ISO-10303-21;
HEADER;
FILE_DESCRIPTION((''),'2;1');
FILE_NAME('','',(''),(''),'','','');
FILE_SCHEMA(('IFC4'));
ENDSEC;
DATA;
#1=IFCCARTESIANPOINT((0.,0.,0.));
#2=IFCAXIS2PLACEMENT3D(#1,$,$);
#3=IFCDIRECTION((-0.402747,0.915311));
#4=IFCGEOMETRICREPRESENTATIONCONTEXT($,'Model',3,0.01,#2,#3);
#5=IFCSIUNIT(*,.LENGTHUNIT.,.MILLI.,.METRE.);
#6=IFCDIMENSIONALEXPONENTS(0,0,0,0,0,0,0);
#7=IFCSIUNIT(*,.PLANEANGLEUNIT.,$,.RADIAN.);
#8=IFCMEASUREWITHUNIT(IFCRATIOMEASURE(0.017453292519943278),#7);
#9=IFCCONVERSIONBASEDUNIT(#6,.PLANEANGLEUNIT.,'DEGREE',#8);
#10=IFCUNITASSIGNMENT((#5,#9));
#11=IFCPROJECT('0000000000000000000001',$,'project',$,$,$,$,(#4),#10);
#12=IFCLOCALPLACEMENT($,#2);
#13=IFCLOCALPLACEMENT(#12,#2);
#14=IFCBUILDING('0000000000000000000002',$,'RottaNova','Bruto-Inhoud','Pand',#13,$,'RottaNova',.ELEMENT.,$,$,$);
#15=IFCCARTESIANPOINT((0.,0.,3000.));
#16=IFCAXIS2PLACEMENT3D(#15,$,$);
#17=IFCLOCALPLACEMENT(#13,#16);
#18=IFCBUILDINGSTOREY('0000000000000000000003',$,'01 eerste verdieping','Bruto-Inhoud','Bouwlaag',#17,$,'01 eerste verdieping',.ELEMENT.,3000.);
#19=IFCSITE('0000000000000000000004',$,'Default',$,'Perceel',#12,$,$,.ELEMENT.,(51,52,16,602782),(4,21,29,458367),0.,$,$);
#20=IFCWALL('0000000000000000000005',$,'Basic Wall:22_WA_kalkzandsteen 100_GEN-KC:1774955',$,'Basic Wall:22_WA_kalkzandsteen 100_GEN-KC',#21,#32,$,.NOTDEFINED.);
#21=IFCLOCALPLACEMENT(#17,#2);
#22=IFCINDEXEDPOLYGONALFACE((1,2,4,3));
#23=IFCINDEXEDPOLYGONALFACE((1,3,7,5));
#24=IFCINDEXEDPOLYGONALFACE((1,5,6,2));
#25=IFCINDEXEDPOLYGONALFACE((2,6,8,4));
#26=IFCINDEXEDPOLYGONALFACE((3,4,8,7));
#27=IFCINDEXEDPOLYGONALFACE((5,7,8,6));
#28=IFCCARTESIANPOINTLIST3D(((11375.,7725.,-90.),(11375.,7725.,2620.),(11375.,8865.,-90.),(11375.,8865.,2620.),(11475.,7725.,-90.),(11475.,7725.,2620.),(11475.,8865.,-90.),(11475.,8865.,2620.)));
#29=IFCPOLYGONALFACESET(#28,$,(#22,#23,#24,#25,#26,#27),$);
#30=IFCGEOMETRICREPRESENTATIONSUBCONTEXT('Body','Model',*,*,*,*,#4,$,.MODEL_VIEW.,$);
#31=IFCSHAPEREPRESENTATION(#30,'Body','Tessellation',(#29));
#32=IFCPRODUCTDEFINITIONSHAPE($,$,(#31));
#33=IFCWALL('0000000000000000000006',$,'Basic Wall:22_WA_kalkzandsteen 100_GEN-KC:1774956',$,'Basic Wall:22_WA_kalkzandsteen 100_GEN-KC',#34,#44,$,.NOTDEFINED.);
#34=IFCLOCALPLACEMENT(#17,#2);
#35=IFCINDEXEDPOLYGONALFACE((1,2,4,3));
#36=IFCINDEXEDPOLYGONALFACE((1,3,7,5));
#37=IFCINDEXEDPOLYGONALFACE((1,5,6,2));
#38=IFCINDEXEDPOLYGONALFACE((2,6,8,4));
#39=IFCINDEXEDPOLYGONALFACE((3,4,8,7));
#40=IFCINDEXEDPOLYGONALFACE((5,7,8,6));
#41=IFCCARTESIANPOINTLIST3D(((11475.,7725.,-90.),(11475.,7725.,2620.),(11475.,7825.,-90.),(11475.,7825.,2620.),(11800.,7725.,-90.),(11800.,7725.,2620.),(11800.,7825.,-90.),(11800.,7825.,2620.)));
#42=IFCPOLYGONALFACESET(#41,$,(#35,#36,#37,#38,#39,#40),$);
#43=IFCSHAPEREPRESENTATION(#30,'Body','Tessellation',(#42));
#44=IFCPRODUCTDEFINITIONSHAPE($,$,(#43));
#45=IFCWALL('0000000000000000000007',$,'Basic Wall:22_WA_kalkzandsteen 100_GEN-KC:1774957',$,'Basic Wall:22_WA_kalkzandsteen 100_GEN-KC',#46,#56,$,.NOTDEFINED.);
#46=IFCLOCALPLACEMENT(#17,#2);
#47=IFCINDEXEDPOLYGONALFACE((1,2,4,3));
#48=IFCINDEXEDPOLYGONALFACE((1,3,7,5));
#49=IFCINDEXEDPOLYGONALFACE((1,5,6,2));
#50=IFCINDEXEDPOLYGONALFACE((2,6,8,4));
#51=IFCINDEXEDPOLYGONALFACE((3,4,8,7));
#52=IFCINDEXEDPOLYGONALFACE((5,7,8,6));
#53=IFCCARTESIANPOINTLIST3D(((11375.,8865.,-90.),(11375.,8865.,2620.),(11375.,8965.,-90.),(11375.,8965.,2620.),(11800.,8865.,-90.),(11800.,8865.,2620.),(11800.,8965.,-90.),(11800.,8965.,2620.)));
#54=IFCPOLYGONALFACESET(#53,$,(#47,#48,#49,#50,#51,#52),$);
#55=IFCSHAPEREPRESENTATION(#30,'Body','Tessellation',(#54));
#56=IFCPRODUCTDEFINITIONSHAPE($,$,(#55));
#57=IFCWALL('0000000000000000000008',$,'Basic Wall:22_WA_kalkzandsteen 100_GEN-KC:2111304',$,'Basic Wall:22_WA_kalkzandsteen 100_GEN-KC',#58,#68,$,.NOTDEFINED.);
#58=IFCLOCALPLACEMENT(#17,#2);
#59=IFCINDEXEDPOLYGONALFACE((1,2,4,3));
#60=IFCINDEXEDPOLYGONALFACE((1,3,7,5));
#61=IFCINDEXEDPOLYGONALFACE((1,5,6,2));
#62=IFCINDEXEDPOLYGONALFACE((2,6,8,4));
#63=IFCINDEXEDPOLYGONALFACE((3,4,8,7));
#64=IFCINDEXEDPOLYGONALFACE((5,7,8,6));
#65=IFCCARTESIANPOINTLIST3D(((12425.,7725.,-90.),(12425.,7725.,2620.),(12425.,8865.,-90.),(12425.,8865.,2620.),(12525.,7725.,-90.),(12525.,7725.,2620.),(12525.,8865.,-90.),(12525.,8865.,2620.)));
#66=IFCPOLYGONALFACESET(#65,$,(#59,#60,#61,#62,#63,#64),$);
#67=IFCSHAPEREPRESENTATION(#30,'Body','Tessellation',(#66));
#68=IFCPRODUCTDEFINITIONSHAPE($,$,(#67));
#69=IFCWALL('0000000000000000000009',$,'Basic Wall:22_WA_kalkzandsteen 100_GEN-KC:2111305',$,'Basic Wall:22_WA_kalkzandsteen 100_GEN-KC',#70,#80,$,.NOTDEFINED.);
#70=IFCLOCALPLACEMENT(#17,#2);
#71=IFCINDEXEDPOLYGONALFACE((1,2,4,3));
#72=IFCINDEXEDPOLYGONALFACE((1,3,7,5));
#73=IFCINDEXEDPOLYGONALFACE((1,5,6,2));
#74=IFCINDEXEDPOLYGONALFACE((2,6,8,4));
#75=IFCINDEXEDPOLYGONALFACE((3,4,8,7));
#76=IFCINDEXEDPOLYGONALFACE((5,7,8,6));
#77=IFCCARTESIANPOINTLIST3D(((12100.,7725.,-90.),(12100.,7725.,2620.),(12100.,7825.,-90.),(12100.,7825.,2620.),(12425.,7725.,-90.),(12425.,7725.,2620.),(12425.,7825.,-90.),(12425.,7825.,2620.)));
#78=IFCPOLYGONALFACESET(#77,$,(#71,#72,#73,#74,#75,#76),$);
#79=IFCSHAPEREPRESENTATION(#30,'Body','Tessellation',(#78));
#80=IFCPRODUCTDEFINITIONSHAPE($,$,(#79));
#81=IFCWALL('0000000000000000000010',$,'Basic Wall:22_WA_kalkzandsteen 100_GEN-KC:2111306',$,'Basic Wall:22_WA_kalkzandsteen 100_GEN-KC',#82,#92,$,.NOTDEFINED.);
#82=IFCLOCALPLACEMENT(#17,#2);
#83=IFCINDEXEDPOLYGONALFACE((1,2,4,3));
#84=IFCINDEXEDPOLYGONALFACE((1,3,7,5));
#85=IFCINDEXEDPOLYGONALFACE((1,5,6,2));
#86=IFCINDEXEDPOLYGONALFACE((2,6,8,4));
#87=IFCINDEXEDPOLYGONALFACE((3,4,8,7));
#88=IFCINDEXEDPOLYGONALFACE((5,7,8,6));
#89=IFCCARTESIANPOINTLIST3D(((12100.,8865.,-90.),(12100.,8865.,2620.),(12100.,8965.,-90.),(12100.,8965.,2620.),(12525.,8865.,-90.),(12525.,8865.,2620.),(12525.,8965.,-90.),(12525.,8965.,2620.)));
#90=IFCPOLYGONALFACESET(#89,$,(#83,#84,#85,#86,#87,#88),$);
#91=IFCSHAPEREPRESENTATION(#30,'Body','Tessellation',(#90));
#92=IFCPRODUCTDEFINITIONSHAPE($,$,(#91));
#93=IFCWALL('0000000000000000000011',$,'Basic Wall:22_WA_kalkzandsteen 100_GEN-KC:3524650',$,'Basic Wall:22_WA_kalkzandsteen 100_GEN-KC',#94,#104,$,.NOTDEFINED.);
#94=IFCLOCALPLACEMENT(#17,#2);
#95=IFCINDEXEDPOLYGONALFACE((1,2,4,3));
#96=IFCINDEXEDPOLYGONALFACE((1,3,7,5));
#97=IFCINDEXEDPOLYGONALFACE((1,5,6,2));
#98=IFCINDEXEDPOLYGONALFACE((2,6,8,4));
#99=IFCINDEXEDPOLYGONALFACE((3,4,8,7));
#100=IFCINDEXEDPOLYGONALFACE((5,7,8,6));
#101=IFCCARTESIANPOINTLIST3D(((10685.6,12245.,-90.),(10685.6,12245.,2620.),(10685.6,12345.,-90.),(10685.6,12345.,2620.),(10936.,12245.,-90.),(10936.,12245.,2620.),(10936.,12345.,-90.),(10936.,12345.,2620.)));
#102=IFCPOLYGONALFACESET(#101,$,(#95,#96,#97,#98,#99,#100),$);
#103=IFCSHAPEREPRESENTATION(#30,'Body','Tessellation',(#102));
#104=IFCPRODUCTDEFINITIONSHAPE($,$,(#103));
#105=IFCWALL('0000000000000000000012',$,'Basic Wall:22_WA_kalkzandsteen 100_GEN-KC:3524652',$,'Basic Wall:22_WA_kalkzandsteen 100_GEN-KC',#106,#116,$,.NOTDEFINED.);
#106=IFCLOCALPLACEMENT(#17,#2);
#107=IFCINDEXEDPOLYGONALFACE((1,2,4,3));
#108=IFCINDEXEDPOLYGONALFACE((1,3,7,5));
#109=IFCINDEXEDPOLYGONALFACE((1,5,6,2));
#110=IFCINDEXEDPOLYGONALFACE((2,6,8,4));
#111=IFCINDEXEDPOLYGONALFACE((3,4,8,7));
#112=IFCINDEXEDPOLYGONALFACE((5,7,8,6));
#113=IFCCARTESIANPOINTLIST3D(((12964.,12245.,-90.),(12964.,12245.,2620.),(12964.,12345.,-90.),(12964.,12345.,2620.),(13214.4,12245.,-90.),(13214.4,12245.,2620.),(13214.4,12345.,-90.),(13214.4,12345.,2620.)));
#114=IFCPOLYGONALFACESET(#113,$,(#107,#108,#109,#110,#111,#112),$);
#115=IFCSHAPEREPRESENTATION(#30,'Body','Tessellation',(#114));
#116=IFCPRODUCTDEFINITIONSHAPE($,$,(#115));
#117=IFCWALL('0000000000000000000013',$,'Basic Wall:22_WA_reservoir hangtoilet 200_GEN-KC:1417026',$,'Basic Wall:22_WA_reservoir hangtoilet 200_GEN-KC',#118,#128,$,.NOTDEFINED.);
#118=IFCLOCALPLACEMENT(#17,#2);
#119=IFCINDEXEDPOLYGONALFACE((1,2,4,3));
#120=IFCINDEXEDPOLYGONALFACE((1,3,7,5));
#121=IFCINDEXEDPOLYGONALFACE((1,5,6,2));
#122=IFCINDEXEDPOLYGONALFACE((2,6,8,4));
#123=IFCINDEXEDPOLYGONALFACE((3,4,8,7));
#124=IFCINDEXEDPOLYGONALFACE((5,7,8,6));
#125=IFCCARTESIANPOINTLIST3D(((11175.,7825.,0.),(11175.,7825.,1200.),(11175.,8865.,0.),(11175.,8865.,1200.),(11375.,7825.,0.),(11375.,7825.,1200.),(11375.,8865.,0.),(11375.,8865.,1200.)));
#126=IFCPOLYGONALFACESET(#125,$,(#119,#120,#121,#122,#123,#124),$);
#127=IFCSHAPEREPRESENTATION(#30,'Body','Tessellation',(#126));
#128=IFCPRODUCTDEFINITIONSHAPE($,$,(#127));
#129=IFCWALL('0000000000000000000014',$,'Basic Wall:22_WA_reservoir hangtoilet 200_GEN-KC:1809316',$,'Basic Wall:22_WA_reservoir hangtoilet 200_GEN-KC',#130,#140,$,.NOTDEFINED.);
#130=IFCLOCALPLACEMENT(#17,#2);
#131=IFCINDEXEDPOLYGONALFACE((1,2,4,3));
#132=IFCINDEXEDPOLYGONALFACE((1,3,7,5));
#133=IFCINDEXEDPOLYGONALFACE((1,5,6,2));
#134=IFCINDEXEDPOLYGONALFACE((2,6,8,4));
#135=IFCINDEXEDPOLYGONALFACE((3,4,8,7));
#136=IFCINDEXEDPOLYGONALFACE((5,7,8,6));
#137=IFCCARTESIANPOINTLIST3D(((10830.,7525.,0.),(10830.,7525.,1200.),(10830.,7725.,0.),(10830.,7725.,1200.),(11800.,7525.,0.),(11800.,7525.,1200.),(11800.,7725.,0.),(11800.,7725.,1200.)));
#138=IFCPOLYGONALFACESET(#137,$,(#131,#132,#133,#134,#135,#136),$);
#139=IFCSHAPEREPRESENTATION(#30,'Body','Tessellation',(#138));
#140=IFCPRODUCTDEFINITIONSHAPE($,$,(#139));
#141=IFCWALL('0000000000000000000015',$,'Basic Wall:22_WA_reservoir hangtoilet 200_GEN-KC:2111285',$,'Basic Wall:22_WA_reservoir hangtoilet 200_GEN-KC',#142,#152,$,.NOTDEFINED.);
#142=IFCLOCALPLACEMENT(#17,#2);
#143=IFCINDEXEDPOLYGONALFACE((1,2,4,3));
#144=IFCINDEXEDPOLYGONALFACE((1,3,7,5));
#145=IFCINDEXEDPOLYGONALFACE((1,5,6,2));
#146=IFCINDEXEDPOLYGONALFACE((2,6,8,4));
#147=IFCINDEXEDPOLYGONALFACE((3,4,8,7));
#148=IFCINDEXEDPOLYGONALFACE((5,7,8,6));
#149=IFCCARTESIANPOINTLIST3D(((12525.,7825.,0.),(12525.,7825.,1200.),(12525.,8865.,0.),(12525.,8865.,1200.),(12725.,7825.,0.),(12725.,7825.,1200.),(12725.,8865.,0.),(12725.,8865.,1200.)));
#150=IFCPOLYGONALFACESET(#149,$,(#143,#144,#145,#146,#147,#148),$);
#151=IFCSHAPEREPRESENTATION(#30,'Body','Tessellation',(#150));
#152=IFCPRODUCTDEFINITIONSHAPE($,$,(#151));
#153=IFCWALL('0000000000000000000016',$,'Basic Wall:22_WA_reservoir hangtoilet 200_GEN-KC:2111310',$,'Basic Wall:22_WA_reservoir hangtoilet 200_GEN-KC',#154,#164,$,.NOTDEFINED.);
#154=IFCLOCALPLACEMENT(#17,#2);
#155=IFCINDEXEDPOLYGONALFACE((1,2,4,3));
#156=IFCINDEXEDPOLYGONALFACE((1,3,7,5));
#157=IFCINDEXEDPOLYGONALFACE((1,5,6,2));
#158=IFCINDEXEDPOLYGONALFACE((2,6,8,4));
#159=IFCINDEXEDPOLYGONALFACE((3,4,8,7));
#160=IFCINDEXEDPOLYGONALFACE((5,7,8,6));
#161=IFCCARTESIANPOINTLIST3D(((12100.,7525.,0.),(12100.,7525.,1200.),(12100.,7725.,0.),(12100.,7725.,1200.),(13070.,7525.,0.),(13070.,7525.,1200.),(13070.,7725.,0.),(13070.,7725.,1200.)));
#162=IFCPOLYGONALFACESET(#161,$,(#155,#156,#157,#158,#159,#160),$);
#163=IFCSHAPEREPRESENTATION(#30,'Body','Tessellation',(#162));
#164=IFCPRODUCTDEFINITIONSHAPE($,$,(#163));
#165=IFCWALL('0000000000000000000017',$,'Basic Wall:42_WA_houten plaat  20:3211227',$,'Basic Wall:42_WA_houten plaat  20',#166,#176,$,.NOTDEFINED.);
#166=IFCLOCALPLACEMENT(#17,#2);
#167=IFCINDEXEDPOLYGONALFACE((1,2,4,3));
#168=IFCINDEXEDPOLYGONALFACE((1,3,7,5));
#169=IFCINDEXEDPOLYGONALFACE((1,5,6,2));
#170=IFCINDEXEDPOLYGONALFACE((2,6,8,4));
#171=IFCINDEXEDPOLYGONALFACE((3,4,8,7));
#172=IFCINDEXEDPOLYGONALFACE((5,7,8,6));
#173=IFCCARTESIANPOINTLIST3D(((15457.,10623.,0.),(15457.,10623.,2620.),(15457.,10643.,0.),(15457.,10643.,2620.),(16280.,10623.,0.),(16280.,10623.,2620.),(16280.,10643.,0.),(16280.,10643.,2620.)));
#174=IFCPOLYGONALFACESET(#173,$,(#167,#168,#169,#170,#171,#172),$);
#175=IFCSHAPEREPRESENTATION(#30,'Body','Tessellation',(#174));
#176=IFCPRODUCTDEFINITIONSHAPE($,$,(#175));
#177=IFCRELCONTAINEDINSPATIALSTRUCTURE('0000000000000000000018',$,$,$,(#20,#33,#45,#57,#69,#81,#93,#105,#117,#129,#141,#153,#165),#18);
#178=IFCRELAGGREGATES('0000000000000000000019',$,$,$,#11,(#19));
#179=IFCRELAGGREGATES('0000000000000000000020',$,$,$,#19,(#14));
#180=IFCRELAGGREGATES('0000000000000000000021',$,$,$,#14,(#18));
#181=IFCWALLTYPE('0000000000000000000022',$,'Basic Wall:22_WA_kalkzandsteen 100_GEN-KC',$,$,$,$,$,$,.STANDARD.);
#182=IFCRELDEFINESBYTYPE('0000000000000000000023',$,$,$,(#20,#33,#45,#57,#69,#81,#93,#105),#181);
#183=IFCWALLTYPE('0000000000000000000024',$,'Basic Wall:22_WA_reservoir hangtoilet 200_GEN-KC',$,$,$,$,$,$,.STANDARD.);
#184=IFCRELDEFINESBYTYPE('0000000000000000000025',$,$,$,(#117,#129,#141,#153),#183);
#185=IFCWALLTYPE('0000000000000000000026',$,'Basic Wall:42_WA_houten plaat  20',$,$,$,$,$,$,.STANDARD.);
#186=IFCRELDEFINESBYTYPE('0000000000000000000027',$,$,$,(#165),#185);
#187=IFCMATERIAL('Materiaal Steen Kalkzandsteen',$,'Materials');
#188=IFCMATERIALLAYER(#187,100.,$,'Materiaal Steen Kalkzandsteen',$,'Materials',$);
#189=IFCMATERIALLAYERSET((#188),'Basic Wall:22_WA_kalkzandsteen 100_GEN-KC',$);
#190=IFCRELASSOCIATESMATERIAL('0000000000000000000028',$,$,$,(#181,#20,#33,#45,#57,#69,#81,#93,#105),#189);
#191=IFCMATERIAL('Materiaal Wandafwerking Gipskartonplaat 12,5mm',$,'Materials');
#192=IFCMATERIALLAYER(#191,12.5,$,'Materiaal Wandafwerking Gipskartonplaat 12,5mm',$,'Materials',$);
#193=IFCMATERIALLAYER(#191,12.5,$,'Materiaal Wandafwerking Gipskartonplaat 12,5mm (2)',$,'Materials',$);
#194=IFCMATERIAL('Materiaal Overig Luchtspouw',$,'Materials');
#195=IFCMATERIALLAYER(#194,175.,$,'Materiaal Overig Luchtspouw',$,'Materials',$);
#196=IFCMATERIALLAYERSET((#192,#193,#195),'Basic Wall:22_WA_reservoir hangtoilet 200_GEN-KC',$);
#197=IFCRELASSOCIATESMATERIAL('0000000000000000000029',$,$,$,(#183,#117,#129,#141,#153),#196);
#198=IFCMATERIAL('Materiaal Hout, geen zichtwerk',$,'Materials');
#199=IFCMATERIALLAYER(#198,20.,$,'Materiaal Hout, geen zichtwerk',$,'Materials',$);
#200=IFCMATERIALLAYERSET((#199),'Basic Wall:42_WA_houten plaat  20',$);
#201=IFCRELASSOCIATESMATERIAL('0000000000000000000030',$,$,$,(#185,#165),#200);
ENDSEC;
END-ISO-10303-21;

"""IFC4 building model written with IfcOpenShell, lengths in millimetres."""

from ifc_helpers import new_model, entity, si_unit, converted_unit, direction, frame, frame_2d, origin, place, context, subcontext, project, spatial, rectangle, extrude, material, layer, layer_set, type_object, element, save


model = new_model("IFC4")

# Units and contexts
model_context = context("Model", 3, precision=0.01, world=origin(), true_north=direction((-0.402747, 0.915311)))
body_context = subcontext(model_context, "Body", "Model", "MODEL_VIEW")
ifc_project = project(units=[si_unit("LENGTHUNIT", "METRE", prefix="MILLI"), converted_unit("PLANEANGLEUNIT", "DEGREE", entity("IfcRatioMeasure", 0.017453292519943278), si_unit("PLANEANGLEUNIT", "RADIAN"), dimensions=[0, 0, 0, 0, 0, 0, 0])], contexts=[model_context])

# Site, building, storey
site_placement = place(None, origin())
site = spatial("IfcSite", under=ifc_project, at=site_placement, Name="Default", ObjectType="Perceel", CompositionType="ELEMENT", RefLatitude=(51, 52, 16, 602782), RefLongitude=(4, 21, 29, 458367), RefElevation=0.0)
building_placement = place(site_placement, origin())
building = spatial("IfcBuilding", under=site, at=building_placement, Name="RottaNova", Description="Bruto-Inhoud", ObjectType="Pand", LongName="RottaNova", CompositionType="ELEMENT")
storey_placement = place(building_placement, frame((0.0, 0.0, 3000.0)))
storey = spatial("IfcBuildingStorey", under=building, at=storey_placement, Name="01 eerste verdieping", Description="Bruto-Inhoud", ObjectType="Bouwlaag", LongName="01 eerste verdieping", CompositionType="ELEMENT", Elevation=3000.0)

# Shared definitions
ifc_material_1 = material(Name="Materiaal Steen Kalkzandsteen", Category="Materials")

# Walls
ifc_layer_1 = layer(ifc_material_1, 100.0, Name="Materiaal Steen Kalkzandsteen", Category="Materials")
ifc_layer_set_1 = layer_set([ifc_layer_1], Name="Basic Wall:22_WA_kalkzandsteen 100_GEN-KC")
wall_type_1 = type_object("IfcWallType", Name="Basic Wall:22_WA_kalkzandsteen 100_GEN-KC", PredefinedType="STANDARD", material=ifc_layer_set_1)
wall_1_placement = place(storey_placement, frame((11425.0, 8865.0, -90.0), z_axis=(0.0, 0.0, 1.0), x_axis=(0.0, -1.0, 0.0)))
element("IfcWall", 1, at=wall_1_placement, inside=storey, type_object=wall_type_1, material=ifc_layer_set_1, Name="Basic Wall:22_WA_kalkzandsteen 100_GEN-KC:1774955", ObjectType="Basic Wall:22_WA_kalkzandsteen 100_GEN-KC", PredefinedType="NOTDEFINED", context=body_context, shape_type="SweptSolid", body=[
    extrude(rectangle(XDim=1140.0, YDim=100.0, at=frame_2d((570.0, 0.0), x_axis=(-1.0, 0.0))), origin(), (0.0, 0.0, 1.0), 2710.0),
])
wall_2_placement = place(storey_placement, frame((11800.0, 7775.0, -90.0), z_axis=(0.0, 0.0, 1.0), x_axis=(-1.0, 0.0, 0.0)))
element("IfcWall", 2, at=wall_2_placement, inside=storey, type_object=wall_type_1, material=ifc_layer_set_1, Name="Basic Wall:22_WA_kalkzandsteen 100_GEN-KC:1774956", ObjectType="Basic Wall:22_WA_kalkzandsteen 100_GEN-KC", PredefinedType="NOTDEFINED", context=body_context, shape_type="SweptSolid", body=[
    extrude(rectangle(XDim=325.0, YDim=100.0, at=frame_2d((162.5, 0.0), x_axis=(-1.0, 0.0))), origin(), (0.0, 0.0, 1.0), 2710.0),
])
wall_3_placement = place(storey_placement, frame((11800.0, 8915.0, -90.0), z_axis=(0.0, 0.0, 1.0), x_axis=(-1.0, 0.0, 0.0)))
element("IfcWall", 3, at=wall_3_placement, inside=storey, type_object=wall_type_1, material=ifc_layer_set_1, Name="Basic Wall:22_WA_kalkzandsteen 100_GEN-KC:1774957", ObjectType="Basic Wall:22_WA_kalkzandsteen 100_GEN-KC", PredefinedType="NOTDEFINED", context=body_context, shape_type="SweptSolid", body=[
    extrude(rectangle(XDim=425.0, YDim=100.0, at=frame_2d((212.5, 0.0), x_axis=(-1.0, 0.0))), origin(), (0.0, 0.0, 1.0), 2710.0),
])
wall_4_placement = place(storey_placement, frame((12475.0, 8865.0, -90.0), z_axis=(0.0, 0.0, 1.0), x_axis=(0.0, -1.0, 0.0)))
element("IfcWall", 4, at=wall_4_placement, inside=storey, type_object=wall_type_1, material=ifc_layer_set_1, Name="Basic Wall:22_WA_kalkzandsteen 100_GEN-KC:2111304", ObjectType="Basic Wall:22_WA_kalkzandsteen 100_GEN-KC", PredefinedType="NOTDEFINED", context=body_context, shape_type="SweptSolid", body=[
    extrude(rectangle(XDim=1140.0, YDim=100.0, at=frame_2d((570.0, 0.0), x_axis=(-1.0, 0.0))), origin(), (0.0, 0.0, 1.0), 2710.0),
])
wall_5_placement = place(storey_placement, frame((12100.0, 7775.0, -90.0)))
element("IfcWall", 5, at=wall_5_placement, inside=storey, type_object=wall_type_1, material=ifc_layer_set_1, Name="Basic Wall:22_WA_kalkzandsteen 100_GEN-KC:2111305", ObjectType="Basic Wall:22_WA_kalkzandsteen 100_GEN-KC", PredefinedType="NOTDEFINED", context=body_context, shape_type="SweptSolid", body=[
    extrude(rectangle(XDim=325.0, YDim=100.0, at=frame_2d((162.5, 0.0), x_axis=(-1.0, 0.0))), origin(), (0.0, 0.0, 1.0), 2710.0),
])
wall_6_placement = place(storey_placement, frame((12100.0, 8915.0, -90.0)))
element("IfcWall", 6, at=wall_6_placement, inside=storey, type_object=wall_type_1, material=ifc_layer_set_1, Name="Basic Wall:22_WA_kalkzandsteen 100_GEN-KC:2111306", ObjectType="Basic Wall:22_WA_kalkzandsteen 100_GEN-KC", PredefinedType="NOTDEFINED", context=body_context, shape_type="SweptSolid", body=[
    extrude(rectangle(XDim=425.0, YDim=100.0, at=frame_2d((212.5, 0.0), x_axis=(-1.0, 0.0))), origin(), (0.0, 0.0, 1.0), 2710.0),
])
wall_7_placement = place(storey_placement, frame((10685.6, 12295.0, -90.0)))
element("IfcWall", 7, at=wall_7_placement, inside=storey, type_object=wall_type_1, material=ifc_layer_set_1, Name="Basic Wall:22_WA_kalkzandsteen 100_GEN-KC:3524650", ObjectType="Basic Wall:22_WA_kalkzandsteen 100_GEN-KC", PredefinedType="NOTDEFINED", context=body_context, shape_type="SweptSolid", body=[
    extrude(rectangle(XDim=250.4, YDim=100.0, at=frame_2d((125.2, 0.0), x_axis=(-1.0, 0.0))), origin(), (0.0, 0.0, 1.0), 2710.0),
])
wall_8_placement = place(storey_placement, frame((13214.4, 12295.0, -90.0), z_axis=(0.0, 0.0, 1.0), x_axis=(-1.0, 0.0, 0.0)))
element("IfcWall", 8, at=wall_8_placement, inside=storey, type_object=wall_type_1, material=ifc_layer_set_1, Name="Basic Wall:22_WA_kalkzandsteen 100_GEN-KC:3524652", ObjectType="Basic Wall:22_WA_kalkzandsteen 100_GEN-KC", PredefinedType="NOTDEFINED", context=body_context, shape_type="SweptSolid", body=[
    extrude(rectangle(XDim=250.4, YDim=100.0, at=frame_2d((125.2, 0.0), x_axis=(-1.0, 0.0))), origin(), (0.0, 0.0, 1.0), 2710.0),
])
ifc_material_2 = material(Name="Materiaal Wandafwerking Gipskartonplaat 12,5mm", Category="Materials")
ifc_layer_2 = layer(ifc_material_2, 12.5, Name="Materiaal Wandafwerking Gipskartonplaat 12,5mm", Category="Materials")
ifc_layer_3 = layer(ifc_material_2, 12.5, Name="Materiaal Wandafwerking Gipskartonplaat 12,5mm (2)", Category="Materials")
ifc_material_3 = material(Name="Materiaal Overig Luchtspouw", Category="Materials")
ifc_layer_4 = layer(ifc_material_3, 175.0, Name="Materiaal Overig Luchtspouw", Category="Materials")
ifc_layer_set_2 = layer_set([ifc_layer_2, ifc_layer_3, ifc_layer_4], Name="Basic Wall:22_WA_reservoir hangtoilet 200_GEN-KC")
wall_type_2 = type_object("IfcWallType", Name="Basic Wall:22_WA_reservoir hangtoilet 200_GEN-KC", PredefinedType="STANDARD", material=ifc_layer_set_2)
wall_9_placement = place(storey_placement, frame((11275.0, 8865.0, 0.0), z_axis=(0.0, 0.0, 1.0), x_axis=(0.0, -1.0, 0.0)))
element("IfcWall", 9, at=wall_9_placement, inside=storey, type_object=wall_type_2, material=ifc_layer_set_2, Name="Basic Wall:22_WA_reservoir hangtoilet 200_GEN-KC:1417026", ObjectType="Basic Wall:22_WA_reservoir hangtoilet 200_GEN-KC", PredefinedType="NOTDEFINED", context=body_context, shape_type="SweptSolid", body=[
    extrude(rectangle(XDim=1040.0, YDim=200.0, at=frame_2d((520.0, 0.0), x_axis=(-1.0, 0.0))), origin(), (0.0, 0.0, 1.0), 1200.0),
])
wall_10_placement = place(storey_placement, frame((10830.0, 7625.0, 0.0)))
element("IfcWall", 10, at=wall_10_placement, inside=storey, type_object=wall_type_2, material=ifc_layer_set_2, Name="Basic Wall:22_WA_reservoir hangtoilet 200_GEN-KC:1809316", ObjectType="Basic Wall:22_WA_reservoir hangtoilet 200_GEN-KC", PredefinedType="NOTDEFINED", context=body_context, shape_type="SweptSolid", body=[
    extrude(rectangle(XDim=970.0, YDim=200.0, at=frame_2d((485.0, 0.0), x_axis=(-1.0, 0.0))), origin(), (0.0, 0.0, 1.0), 1200.0),
])
wall_11_placement = place(storey_placement, frame((12625.0, 8865.0, 0.0), z_axis=(0.0, 0.0, 1.0), x_axis=(0.0, -1.0, 0.0)))
element("IfcWall", 11, at=wall_11_placement, inside=storey, type_object=wall_type_2, material=ifc_layer_set_2, Name="Basic Wall:22_WA_reservoir hangtoilet 200_GEN-KC:2111285", ObjectType="Basic Wall:22_WA_reservoir hangtoilet 200_GEN-KC", PredefinedType="NOTDEFINED", context=body_context, shape_type="SweptSolid", body=[
    extrude(rectangle(XDim=1040.0, YDim=200.0, at=frame_2d((520.0, 0.0), x_axis=(-1.0, 0.0))), origin(), (0.0, 0.0, 1.0), 1200.0),
])
wall_12_placement = place(storey_placement, frame((13070.0, 7625.0, 0.0), z_axis=(0.0, 0.0, 1.0), x_axis=(-1.0, 0.0, 0.0)))
element("IfcWall", 12, at=wall_12_placement, inside=storey, type_object=wall_type_2, material=ifc_layer_set_2, Name="Basic Wall:22_WA_reservoir hangtoilet 200_GEN-KC:2111310", ObjectType="Basic Wall:22_WA_reservoir hangtoilet 200_GEN-KC", PredefinedType="NOTDEFINED", context=body_context, shape_type="SweptSolid", body=[
    extrude(rectangle(XDim=970.0, YDim=200.0, at=frame_2d((485.0, 0.0), x_axis=(-1.0, 0.0))), origin(), (0.0, 0.0, 1.0), 1200.0),
])
ifc_material_4 = material(Name="Materiaal Hout, geen zichtwerk", Category="Materials")
ifc_layer_5 = layer(ifc_material_4, 20.0, Name="Materiaal Hout, geen zichtwerk", Category="Materials")
ifc_layer_set_3 = layer_set([ifc_layer_5], Name="Basic Wall:42_WA_houten plaat  20")
wall_type_3 = type_object("IfcWallType", Name="Basic Wall:42_WA_houten plaat  20", PredefinedType="STANDARD", material=ifc_layer_set_3)
wall_13_placement = place(storey_placement, frame((16280.0, 10633.0, 0.0), z_axis=(0.0, 0.0, 1.0), x_axis=(-1.0, 0.0, 0.0)))
element("IfcWall", 13, at=wall_13_placement, inside=storey, type_object=wall_type_3, material=ifc_layer_set_3, Name="Basic Wall:42_WA_houten plaat  20:3211227", ObjectType="Basic Wall:42_WA_houten plaat  20", PredefinedType="NOTDEFINED", context=body_context, shape_type="SweptSolid", body=[
    extrude(rectangle(XDim=823.0, YDim=20.0, at=frame_2d((411.5, 0.0), x_axis=(-1.0, 0.0))), origin(), (0.0, 0.0, 1.0), 2620.0),
])

save(model, "model.ifc")
